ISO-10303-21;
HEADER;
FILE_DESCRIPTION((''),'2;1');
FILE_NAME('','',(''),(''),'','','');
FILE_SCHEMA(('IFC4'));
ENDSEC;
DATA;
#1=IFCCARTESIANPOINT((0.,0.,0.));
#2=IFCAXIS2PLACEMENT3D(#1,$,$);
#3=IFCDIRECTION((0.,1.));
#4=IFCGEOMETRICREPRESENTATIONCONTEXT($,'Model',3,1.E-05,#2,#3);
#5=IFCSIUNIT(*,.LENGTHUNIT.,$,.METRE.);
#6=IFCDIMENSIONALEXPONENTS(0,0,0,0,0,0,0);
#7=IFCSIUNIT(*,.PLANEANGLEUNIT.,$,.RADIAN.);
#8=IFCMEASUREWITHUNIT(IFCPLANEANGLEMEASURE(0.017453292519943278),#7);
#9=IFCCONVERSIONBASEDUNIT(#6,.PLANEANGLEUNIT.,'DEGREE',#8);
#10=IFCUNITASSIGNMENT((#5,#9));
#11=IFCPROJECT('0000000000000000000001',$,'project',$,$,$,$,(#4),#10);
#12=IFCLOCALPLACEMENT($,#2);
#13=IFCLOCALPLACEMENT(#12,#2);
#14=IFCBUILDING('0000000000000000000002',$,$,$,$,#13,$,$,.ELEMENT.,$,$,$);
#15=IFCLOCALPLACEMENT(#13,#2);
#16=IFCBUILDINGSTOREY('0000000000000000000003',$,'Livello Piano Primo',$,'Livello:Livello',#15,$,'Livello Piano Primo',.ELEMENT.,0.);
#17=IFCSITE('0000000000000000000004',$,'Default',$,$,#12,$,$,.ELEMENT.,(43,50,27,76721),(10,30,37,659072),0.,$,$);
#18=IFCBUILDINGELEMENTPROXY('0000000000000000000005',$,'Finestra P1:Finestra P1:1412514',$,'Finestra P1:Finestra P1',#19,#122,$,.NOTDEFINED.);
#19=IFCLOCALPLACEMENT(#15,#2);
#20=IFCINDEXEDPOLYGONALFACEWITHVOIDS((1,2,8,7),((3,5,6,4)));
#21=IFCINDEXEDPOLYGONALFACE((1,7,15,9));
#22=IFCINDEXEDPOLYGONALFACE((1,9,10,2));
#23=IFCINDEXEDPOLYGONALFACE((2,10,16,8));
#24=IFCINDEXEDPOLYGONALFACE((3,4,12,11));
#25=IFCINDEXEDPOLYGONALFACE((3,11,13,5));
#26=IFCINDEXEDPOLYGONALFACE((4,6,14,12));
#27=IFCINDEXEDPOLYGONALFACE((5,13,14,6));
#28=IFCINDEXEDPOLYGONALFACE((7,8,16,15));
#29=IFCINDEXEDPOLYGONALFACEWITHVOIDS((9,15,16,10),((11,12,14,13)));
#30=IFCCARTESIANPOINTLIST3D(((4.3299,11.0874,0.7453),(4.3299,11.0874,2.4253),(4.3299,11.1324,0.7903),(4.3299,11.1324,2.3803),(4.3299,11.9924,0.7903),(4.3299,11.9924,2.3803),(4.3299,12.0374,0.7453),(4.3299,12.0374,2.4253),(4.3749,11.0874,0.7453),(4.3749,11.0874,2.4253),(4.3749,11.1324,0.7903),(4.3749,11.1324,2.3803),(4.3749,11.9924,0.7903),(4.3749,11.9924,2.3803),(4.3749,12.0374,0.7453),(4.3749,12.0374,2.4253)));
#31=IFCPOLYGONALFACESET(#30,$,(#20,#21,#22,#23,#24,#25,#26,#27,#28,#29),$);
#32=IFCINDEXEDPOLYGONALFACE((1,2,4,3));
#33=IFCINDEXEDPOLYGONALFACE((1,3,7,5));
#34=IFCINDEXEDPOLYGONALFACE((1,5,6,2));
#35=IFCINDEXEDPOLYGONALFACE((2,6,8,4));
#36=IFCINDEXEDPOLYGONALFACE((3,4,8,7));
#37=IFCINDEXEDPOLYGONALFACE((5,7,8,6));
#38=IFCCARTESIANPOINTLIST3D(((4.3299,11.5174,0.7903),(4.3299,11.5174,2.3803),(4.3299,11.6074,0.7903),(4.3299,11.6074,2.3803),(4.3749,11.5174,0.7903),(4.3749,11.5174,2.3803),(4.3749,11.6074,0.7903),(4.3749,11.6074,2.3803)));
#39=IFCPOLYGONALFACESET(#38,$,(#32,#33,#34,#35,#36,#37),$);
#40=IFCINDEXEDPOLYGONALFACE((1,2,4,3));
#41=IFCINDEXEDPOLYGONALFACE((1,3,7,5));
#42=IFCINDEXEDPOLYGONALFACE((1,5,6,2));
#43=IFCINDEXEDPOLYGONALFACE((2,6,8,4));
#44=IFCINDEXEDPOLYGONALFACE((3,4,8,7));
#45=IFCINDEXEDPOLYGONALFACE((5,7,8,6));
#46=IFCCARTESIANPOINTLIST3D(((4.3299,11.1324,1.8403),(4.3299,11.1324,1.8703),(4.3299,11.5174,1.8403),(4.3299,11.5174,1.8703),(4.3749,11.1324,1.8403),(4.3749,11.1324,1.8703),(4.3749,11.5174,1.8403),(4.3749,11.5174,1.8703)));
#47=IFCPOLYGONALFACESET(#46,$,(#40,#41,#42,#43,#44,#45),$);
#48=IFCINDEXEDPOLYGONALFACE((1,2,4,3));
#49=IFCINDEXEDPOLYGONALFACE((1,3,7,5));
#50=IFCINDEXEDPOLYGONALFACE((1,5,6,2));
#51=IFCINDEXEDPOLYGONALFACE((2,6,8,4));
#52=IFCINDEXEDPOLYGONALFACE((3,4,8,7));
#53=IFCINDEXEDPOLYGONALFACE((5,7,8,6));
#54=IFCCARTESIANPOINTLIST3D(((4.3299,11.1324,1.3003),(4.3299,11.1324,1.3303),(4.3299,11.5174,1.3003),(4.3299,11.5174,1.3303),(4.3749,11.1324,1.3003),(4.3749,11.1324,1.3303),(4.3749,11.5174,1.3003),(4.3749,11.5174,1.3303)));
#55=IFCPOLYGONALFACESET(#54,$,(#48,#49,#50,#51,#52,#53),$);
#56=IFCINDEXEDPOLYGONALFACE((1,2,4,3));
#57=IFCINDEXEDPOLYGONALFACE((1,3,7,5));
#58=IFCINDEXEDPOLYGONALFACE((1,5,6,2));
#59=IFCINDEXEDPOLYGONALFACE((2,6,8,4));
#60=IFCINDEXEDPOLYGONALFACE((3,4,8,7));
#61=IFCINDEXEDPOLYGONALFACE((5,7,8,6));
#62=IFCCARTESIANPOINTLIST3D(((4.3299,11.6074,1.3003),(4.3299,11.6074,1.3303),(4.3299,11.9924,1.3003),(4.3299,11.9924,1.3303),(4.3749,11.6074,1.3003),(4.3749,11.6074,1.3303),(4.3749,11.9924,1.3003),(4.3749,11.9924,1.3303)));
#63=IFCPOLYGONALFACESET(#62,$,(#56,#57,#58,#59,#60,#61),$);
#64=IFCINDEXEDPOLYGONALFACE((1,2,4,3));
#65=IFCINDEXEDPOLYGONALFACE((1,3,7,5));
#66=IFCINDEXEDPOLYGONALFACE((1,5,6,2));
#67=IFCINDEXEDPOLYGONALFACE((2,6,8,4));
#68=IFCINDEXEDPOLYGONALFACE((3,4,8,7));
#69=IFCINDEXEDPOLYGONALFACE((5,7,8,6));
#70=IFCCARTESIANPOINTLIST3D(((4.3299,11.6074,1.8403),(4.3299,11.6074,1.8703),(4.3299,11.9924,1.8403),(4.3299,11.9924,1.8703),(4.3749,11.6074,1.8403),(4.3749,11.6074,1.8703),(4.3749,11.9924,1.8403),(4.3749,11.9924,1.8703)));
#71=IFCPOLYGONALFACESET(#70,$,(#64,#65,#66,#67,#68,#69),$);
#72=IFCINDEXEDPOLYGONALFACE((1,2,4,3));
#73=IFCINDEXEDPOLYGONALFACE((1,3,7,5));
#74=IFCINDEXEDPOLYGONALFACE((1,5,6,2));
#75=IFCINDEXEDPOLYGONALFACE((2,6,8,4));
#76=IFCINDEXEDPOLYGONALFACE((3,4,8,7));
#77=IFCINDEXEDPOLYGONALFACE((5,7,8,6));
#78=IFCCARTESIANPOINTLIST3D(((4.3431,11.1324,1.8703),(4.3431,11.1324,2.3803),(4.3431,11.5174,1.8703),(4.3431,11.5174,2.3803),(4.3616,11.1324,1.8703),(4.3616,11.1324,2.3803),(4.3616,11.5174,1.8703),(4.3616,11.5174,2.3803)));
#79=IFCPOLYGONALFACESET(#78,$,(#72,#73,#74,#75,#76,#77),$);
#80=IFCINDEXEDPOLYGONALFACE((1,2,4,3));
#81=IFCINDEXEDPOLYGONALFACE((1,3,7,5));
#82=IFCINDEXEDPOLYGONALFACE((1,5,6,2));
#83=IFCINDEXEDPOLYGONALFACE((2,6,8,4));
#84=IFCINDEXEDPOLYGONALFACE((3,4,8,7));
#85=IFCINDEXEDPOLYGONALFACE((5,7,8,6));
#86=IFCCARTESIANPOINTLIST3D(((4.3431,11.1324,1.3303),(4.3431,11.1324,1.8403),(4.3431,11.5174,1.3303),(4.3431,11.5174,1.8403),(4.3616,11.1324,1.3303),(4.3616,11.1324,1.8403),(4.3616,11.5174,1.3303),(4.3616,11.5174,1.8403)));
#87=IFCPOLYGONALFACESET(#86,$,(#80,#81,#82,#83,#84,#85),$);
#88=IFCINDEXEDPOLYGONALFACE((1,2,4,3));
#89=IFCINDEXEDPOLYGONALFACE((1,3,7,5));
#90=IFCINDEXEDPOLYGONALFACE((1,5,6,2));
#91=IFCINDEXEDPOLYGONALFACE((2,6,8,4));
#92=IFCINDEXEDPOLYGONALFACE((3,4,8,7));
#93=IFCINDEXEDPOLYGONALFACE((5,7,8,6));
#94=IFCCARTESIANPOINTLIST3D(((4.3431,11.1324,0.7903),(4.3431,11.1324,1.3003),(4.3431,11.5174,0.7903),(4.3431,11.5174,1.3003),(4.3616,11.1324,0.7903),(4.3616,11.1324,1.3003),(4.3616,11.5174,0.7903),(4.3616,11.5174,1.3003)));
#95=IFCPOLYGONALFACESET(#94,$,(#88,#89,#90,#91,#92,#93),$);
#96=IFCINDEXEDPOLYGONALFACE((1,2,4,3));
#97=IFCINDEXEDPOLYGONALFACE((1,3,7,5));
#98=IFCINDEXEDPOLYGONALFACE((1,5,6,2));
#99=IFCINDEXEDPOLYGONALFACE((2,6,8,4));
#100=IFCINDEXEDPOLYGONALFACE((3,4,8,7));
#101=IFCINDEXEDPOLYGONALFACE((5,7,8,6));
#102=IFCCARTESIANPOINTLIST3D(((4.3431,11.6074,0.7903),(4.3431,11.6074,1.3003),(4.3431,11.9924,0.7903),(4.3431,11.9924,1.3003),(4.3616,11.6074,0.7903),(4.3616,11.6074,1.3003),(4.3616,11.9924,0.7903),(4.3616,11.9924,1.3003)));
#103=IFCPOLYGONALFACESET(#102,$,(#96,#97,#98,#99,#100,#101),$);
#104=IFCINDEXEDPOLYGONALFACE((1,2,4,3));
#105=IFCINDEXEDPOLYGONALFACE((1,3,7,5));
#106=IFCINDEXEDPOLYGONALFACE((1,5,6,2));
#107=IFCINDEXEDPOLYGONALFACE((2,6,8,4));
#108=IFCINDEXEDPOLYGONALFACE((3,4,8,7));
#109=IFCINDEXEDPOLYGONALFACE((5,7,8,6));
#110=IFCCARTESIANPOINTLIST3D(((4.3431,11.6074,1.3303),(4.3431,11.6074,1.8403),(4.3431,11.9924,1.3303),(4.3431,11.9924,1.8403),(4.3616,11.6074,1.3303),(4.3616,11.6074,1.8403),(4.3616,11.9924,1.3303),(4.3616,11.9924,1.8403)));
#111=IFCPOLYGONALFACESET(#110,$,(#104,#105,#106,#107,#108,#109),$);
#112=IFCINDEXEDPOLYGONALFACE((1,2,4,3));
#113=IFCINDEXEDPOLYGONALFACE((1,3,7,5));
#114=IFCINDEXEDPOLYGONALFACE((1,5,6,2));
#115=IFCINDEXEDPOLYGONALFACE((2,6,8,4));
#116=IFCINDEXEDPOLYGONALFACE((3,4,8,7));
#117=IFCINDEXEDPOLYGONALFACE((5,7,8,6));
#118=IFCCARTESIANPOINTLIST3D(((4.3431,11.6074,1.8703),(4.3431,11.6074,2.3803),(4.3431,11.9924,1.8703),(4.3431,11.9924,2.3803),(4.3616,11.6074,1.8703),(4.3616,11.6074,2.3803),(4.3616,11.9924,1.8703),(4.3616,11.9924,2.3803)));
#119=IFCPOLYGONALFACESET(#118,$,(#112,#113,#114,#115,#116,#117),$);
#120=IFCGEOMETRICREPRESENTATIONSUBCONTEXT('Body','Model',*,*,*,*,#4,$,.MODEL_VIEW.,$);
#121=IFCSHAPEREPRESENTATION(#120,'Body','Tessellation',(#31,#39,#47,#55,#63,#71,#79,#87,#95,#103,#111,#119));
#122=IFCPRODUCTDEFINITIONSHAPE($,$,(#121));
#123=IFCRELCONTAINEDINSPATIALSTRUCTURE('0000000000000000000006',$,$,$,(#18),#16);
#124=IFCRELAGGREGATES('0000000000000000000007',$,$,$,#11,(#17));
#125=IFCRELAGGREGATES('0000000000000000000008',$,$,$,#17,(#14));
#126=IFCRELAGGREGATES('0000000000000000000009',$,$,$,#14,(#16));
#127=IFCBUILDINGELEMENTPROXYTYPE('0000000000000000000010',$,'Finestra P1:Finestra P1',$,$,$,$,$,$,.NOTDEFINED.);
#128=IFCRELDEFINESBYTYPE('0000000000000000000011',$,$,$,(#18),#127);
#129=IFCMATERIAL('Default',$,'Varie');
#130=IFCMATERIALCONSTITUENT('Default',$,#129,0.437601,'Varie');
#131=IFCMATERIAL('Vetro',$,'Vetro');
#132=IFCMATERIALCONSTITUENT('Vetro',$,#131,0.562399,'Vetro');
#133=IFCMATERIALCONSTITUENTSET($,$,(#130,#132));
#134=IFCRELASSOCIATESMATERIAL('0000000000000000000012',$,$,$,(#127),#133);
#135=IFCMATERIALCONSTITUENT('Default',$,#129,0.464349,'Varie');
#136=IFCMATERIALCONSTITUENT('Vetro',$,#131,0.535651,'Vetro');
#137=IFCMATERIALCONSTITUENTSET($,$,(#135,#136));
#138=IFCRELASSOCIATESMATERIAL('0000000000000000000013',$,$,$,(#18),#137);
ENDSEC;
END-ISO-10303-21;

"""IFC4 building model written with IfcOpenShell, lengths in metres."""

from ifc_helpers import new_model, entity, si_unit, converted_unit, direction, frame, origin, place, context, subcontext, project, spatial, indexed_curve, outline, extrude, source, transform, mapped, material, constituent, constituent_set, type_object, type_shapes, element, save


model = new_model("IFC4")

# Units and contexts
model_context = context("Model", 3, precision=1e-05, world=origin(), true_north=direction((0.0, 1.0)))
body_context = subcontext(model_context, "Body", "Model", "MODEL_VIEW")
ifc_project = project(units=[si_unit("LENGTHUNIT", "METRE"), converted_unit("PLANEANGLEUNIT", "DEGREE", entity("IfcPlaneAngleMeasure", 0.017453292519943278), si_unit("PLANEANGLEUNIT", "RADIAN"), dimensions=[0, 0, 0, 0, 0, 0, 0])], contexts=[model_context])

# Site, building, storey
site_placement = place(None, origin())
site = spatial("IfcSite", under=ifc_project, at=site_placement, Name="Default", CompositionType="ELEMENT", RefLatitude=(43, 50, 27, 76721), RefLongitude=(10, 30, 37, 659072), RefElevation=0.0)
building_placement = place(site_placement, origin())
building = spatial("IfcBuilding", under=site, at=building_placement, CompositionType="ELEMENT")
storey_placement = place(building_placement, origin())
storey = spatial("IfcBuildingStorey", under=building, at=storey_placement, Name="Livello Piano Primo", ObjectType="Livello:Livello", LongName="Livello Piano Primo", CompositionType="ELEMENT", Elevation=0.0)

# Building element proxy
ifc_material_1 = material(Name="Default", Category="Varie")
ifc_material_2 = material(Name="Vetro", Category="Vetro")
ifc_constituent_1 = constituent(ifc_material_1, Name="Default", Category="Varie", fraction=0.464349)
ifc_constituent_2 = constituent(ifc_material_2, Name="Vetro", Category="Vetro", fraction=0.535651)
ifc_constituent_set_1 = constituent_set(constituents=[ifc_constituent_1, ifc_constituent_2])
ifc_constituent_3 = constituent(ifc_material_1, Name="Default", Category="Varie", fraction=0.437601)
ifc_constituent_4 = constituent(ifc_material_2, Name="Vetro", Category="Vetro", fraction=0.562399)
ifc_constituent_set_2 = constituent_set(constituents=[ifc_constituent_3, ifc_constituent_4])
building_element_proxy_type_1 = type_object("IfcBuildingElementProxyType", Name="Finestra P1:Finestra P1", PredefinedType="NOTDEFINED", material=ifc_constituent_set_2)
shared_shape_1 = source(origin(), body_context, "Body", "SweptSolid", [
    extrude(outline(indexed_curve([(-0.84, -0.475), (0.84, -0.475), (0.84, 0.475), (-0.84, 0.475), (-0.84, -0.475)], self_intersect=False), holes=[indexed_curve([(0.795, -0.43), (-0.795, -0.43), (-0.795, 0.43), (0.795, 0.43), (0.795, -0.43)], self_intersect=False)]), frame((0.0, -0.0225, 0.84), z_axis=(0.0, 1.0, 0.0), x_axis=(0.0, 0.0, -1.0)), (0.0, 0.0, 1.0), 0.045),
    extrude(outline(indexed_curve([(-0.045, -0.0225), (0.045, -0.0225), (0.045, 0.0225), (-0.045, 0.0225), (-0.045, -0.0225)], self_intersect=False)), frame((0.0, 0.0, 0.045), z_axis=(0.0, 0.0, 1.0), x_axis=(-1.0, 0.0, 0.0)), (0.0, 0.0, 1.0), 1.59),
    extrude(outline(indexed_curve([(-0.1925, -0.0225), (0.1925, -0.0225), (0.1925, 0.0225), (-0.1925, 0.0225), (-0.1925, -0.0225)], self_intersect=False)), frame((0.2375, 0.0, 1.095)), (0.0, 0.0, 1.0), 0.03),
    extrude(outline(indexed_curve([(-0.1925, -0.0225), (0.1925, -0.0225), (0.1925, 0.0225), (-0.1925, 0.0225), (-0.1925, -0.0225)], self_intersect=False)), frame((0.2375, 0.0, 0.555)), (0.0, 0.0, 1.0), 0.03),
    extrude(outline(indexed_curve([(-0.1925, -0.0225), (0.1925, -0.0225), (0.1925, 0.0225), (-0.1925, 0.0225), (-0.1925, -0.0225)], self_intersect=False)), frame((-0.2375, 0.0, 0.555)), (0.0, 0.0, 1.0), 0.03),
    extrude(outline(indexed_curve([(-0.1925, -0.0225), (0.1925, -0.0225), (0.1925, 0.0225), (-0.1925, 0.0225), (-0.1925, -0.0225)], self_intersect=False)), frame((-0.2375, 0.0, 1.095)), (0.0, 0.0, 1.0), 0.03),
    extrude(outline(indexed_curve([(-0.1925, -0.0092), (0.1925, -0.0092), (0.1925, 0.0092), (-0.1925, 0.0092), (-0.1925, -0.0092)], self_intersect=False)), frame((0.2375, 0.0, 1.125), z_axis=(0.0, 0.0, 1.0), x_axis=(-1.0, 0.0, 0.0)), (0.0, 0.0, 1.0), 0.51),
    extrude(outline(indexed_curve([(-0.1925, -0.0092), (0.1925, -0.0092), (0.1925, 0.0092), (-0.1925, 0.0092), (-0.1925, -0.0092)], self_intersect=False)), frame((0.2375, 0.0, 0.585), z_axis=(0.0, 0.0, 1.0), x_axis=(-1.0, 0.0, 0.0)), (0.0, 0.0, 1.0), 0.51),
    extrude(outline(indexed_curve([(-0.1925, -0.0092), (0.1925, -0.0092), (0.1925, 0.0092), (-0.1925, 0.0092), (-0.1925, -0.0092)], self_intersect=False)), frame((0.2375, 0.0, 0.045), z_axis=(0.0, 0.0, 1.0), x_axis=(-1.0, 0.0, 0.0)), (0.0, 0.0, 1.0), 0.51),
    extrude(outline(indexed_curve([(-0.1925, -0.0092), (0.1925, -0.0092), (0.1925, 0.0092), (-0.1925, 0.0092), (-0.1925, -0.0092)], self_intersect=False)), frame((-0.2375, 0.0, 0.045), z_axis=(0.0, 0.0, 1.0), x_axis=(-1.0, 0.0, 0.0)), (0.0, 0.0, 1.0), 0.51),
    extrude(outline(indexed_curve([(-0.1925, -0.0092), (0.1925, -0.0092), (0.1925, 0.0092), (-0.1925, 0.0092), (-0.1925, -0.0092)], self_intersect=False)), frame((-0.2375, 0.0, 0.585), z_axis=(0.0, 0.0, 1.0), x_axis=(-1.0, 0.0, 0.0)), (0.0, 0.0, 1.0), 0.51),
    extrude(outline(indexed_curve([(-0.1925, -0.0092), (0.1925, -0.0092), (0.1925, 0.0092), (-0.1925, 0.0092), (-0.1925, -0.0092)], self_intersect=False)), frame((-0.2375, 0.0, 1.125), z_axis=(0.0, 0.0, 1.0), x_axis=(-1.0, 0.0, 0.0)), (0.0, 0.0, 1.0), 0.51),
])
type_shapes(building_element_proxy_type_1, [shared_shape_1])
proxy_1_placement = place(storey_placement, frame((4.3524, 11.5624, 0.7453), z_axis=(0.0, 0.0, 1.0), x_axis=(0.0, -1.0, 0.0)))
element("IfcBuildingElementProxy", 1, at=proxy_1_placement, inside=storey, type_object=building_element_proxy_type_1, material=ifc_constituent_set_1, Name="Finestra P1:Finestra P1:1412514", ObjectType="Finestra P1:Finestra P1", PredefinedType="NOTDEFINED", context=body_context, shape_type="MappedRepresentation", body=[
    mapped(shared_shape_1, transform((0.0, 0.0, 0.0), scale=1.0)),
])

save(model, "model.ifc")
